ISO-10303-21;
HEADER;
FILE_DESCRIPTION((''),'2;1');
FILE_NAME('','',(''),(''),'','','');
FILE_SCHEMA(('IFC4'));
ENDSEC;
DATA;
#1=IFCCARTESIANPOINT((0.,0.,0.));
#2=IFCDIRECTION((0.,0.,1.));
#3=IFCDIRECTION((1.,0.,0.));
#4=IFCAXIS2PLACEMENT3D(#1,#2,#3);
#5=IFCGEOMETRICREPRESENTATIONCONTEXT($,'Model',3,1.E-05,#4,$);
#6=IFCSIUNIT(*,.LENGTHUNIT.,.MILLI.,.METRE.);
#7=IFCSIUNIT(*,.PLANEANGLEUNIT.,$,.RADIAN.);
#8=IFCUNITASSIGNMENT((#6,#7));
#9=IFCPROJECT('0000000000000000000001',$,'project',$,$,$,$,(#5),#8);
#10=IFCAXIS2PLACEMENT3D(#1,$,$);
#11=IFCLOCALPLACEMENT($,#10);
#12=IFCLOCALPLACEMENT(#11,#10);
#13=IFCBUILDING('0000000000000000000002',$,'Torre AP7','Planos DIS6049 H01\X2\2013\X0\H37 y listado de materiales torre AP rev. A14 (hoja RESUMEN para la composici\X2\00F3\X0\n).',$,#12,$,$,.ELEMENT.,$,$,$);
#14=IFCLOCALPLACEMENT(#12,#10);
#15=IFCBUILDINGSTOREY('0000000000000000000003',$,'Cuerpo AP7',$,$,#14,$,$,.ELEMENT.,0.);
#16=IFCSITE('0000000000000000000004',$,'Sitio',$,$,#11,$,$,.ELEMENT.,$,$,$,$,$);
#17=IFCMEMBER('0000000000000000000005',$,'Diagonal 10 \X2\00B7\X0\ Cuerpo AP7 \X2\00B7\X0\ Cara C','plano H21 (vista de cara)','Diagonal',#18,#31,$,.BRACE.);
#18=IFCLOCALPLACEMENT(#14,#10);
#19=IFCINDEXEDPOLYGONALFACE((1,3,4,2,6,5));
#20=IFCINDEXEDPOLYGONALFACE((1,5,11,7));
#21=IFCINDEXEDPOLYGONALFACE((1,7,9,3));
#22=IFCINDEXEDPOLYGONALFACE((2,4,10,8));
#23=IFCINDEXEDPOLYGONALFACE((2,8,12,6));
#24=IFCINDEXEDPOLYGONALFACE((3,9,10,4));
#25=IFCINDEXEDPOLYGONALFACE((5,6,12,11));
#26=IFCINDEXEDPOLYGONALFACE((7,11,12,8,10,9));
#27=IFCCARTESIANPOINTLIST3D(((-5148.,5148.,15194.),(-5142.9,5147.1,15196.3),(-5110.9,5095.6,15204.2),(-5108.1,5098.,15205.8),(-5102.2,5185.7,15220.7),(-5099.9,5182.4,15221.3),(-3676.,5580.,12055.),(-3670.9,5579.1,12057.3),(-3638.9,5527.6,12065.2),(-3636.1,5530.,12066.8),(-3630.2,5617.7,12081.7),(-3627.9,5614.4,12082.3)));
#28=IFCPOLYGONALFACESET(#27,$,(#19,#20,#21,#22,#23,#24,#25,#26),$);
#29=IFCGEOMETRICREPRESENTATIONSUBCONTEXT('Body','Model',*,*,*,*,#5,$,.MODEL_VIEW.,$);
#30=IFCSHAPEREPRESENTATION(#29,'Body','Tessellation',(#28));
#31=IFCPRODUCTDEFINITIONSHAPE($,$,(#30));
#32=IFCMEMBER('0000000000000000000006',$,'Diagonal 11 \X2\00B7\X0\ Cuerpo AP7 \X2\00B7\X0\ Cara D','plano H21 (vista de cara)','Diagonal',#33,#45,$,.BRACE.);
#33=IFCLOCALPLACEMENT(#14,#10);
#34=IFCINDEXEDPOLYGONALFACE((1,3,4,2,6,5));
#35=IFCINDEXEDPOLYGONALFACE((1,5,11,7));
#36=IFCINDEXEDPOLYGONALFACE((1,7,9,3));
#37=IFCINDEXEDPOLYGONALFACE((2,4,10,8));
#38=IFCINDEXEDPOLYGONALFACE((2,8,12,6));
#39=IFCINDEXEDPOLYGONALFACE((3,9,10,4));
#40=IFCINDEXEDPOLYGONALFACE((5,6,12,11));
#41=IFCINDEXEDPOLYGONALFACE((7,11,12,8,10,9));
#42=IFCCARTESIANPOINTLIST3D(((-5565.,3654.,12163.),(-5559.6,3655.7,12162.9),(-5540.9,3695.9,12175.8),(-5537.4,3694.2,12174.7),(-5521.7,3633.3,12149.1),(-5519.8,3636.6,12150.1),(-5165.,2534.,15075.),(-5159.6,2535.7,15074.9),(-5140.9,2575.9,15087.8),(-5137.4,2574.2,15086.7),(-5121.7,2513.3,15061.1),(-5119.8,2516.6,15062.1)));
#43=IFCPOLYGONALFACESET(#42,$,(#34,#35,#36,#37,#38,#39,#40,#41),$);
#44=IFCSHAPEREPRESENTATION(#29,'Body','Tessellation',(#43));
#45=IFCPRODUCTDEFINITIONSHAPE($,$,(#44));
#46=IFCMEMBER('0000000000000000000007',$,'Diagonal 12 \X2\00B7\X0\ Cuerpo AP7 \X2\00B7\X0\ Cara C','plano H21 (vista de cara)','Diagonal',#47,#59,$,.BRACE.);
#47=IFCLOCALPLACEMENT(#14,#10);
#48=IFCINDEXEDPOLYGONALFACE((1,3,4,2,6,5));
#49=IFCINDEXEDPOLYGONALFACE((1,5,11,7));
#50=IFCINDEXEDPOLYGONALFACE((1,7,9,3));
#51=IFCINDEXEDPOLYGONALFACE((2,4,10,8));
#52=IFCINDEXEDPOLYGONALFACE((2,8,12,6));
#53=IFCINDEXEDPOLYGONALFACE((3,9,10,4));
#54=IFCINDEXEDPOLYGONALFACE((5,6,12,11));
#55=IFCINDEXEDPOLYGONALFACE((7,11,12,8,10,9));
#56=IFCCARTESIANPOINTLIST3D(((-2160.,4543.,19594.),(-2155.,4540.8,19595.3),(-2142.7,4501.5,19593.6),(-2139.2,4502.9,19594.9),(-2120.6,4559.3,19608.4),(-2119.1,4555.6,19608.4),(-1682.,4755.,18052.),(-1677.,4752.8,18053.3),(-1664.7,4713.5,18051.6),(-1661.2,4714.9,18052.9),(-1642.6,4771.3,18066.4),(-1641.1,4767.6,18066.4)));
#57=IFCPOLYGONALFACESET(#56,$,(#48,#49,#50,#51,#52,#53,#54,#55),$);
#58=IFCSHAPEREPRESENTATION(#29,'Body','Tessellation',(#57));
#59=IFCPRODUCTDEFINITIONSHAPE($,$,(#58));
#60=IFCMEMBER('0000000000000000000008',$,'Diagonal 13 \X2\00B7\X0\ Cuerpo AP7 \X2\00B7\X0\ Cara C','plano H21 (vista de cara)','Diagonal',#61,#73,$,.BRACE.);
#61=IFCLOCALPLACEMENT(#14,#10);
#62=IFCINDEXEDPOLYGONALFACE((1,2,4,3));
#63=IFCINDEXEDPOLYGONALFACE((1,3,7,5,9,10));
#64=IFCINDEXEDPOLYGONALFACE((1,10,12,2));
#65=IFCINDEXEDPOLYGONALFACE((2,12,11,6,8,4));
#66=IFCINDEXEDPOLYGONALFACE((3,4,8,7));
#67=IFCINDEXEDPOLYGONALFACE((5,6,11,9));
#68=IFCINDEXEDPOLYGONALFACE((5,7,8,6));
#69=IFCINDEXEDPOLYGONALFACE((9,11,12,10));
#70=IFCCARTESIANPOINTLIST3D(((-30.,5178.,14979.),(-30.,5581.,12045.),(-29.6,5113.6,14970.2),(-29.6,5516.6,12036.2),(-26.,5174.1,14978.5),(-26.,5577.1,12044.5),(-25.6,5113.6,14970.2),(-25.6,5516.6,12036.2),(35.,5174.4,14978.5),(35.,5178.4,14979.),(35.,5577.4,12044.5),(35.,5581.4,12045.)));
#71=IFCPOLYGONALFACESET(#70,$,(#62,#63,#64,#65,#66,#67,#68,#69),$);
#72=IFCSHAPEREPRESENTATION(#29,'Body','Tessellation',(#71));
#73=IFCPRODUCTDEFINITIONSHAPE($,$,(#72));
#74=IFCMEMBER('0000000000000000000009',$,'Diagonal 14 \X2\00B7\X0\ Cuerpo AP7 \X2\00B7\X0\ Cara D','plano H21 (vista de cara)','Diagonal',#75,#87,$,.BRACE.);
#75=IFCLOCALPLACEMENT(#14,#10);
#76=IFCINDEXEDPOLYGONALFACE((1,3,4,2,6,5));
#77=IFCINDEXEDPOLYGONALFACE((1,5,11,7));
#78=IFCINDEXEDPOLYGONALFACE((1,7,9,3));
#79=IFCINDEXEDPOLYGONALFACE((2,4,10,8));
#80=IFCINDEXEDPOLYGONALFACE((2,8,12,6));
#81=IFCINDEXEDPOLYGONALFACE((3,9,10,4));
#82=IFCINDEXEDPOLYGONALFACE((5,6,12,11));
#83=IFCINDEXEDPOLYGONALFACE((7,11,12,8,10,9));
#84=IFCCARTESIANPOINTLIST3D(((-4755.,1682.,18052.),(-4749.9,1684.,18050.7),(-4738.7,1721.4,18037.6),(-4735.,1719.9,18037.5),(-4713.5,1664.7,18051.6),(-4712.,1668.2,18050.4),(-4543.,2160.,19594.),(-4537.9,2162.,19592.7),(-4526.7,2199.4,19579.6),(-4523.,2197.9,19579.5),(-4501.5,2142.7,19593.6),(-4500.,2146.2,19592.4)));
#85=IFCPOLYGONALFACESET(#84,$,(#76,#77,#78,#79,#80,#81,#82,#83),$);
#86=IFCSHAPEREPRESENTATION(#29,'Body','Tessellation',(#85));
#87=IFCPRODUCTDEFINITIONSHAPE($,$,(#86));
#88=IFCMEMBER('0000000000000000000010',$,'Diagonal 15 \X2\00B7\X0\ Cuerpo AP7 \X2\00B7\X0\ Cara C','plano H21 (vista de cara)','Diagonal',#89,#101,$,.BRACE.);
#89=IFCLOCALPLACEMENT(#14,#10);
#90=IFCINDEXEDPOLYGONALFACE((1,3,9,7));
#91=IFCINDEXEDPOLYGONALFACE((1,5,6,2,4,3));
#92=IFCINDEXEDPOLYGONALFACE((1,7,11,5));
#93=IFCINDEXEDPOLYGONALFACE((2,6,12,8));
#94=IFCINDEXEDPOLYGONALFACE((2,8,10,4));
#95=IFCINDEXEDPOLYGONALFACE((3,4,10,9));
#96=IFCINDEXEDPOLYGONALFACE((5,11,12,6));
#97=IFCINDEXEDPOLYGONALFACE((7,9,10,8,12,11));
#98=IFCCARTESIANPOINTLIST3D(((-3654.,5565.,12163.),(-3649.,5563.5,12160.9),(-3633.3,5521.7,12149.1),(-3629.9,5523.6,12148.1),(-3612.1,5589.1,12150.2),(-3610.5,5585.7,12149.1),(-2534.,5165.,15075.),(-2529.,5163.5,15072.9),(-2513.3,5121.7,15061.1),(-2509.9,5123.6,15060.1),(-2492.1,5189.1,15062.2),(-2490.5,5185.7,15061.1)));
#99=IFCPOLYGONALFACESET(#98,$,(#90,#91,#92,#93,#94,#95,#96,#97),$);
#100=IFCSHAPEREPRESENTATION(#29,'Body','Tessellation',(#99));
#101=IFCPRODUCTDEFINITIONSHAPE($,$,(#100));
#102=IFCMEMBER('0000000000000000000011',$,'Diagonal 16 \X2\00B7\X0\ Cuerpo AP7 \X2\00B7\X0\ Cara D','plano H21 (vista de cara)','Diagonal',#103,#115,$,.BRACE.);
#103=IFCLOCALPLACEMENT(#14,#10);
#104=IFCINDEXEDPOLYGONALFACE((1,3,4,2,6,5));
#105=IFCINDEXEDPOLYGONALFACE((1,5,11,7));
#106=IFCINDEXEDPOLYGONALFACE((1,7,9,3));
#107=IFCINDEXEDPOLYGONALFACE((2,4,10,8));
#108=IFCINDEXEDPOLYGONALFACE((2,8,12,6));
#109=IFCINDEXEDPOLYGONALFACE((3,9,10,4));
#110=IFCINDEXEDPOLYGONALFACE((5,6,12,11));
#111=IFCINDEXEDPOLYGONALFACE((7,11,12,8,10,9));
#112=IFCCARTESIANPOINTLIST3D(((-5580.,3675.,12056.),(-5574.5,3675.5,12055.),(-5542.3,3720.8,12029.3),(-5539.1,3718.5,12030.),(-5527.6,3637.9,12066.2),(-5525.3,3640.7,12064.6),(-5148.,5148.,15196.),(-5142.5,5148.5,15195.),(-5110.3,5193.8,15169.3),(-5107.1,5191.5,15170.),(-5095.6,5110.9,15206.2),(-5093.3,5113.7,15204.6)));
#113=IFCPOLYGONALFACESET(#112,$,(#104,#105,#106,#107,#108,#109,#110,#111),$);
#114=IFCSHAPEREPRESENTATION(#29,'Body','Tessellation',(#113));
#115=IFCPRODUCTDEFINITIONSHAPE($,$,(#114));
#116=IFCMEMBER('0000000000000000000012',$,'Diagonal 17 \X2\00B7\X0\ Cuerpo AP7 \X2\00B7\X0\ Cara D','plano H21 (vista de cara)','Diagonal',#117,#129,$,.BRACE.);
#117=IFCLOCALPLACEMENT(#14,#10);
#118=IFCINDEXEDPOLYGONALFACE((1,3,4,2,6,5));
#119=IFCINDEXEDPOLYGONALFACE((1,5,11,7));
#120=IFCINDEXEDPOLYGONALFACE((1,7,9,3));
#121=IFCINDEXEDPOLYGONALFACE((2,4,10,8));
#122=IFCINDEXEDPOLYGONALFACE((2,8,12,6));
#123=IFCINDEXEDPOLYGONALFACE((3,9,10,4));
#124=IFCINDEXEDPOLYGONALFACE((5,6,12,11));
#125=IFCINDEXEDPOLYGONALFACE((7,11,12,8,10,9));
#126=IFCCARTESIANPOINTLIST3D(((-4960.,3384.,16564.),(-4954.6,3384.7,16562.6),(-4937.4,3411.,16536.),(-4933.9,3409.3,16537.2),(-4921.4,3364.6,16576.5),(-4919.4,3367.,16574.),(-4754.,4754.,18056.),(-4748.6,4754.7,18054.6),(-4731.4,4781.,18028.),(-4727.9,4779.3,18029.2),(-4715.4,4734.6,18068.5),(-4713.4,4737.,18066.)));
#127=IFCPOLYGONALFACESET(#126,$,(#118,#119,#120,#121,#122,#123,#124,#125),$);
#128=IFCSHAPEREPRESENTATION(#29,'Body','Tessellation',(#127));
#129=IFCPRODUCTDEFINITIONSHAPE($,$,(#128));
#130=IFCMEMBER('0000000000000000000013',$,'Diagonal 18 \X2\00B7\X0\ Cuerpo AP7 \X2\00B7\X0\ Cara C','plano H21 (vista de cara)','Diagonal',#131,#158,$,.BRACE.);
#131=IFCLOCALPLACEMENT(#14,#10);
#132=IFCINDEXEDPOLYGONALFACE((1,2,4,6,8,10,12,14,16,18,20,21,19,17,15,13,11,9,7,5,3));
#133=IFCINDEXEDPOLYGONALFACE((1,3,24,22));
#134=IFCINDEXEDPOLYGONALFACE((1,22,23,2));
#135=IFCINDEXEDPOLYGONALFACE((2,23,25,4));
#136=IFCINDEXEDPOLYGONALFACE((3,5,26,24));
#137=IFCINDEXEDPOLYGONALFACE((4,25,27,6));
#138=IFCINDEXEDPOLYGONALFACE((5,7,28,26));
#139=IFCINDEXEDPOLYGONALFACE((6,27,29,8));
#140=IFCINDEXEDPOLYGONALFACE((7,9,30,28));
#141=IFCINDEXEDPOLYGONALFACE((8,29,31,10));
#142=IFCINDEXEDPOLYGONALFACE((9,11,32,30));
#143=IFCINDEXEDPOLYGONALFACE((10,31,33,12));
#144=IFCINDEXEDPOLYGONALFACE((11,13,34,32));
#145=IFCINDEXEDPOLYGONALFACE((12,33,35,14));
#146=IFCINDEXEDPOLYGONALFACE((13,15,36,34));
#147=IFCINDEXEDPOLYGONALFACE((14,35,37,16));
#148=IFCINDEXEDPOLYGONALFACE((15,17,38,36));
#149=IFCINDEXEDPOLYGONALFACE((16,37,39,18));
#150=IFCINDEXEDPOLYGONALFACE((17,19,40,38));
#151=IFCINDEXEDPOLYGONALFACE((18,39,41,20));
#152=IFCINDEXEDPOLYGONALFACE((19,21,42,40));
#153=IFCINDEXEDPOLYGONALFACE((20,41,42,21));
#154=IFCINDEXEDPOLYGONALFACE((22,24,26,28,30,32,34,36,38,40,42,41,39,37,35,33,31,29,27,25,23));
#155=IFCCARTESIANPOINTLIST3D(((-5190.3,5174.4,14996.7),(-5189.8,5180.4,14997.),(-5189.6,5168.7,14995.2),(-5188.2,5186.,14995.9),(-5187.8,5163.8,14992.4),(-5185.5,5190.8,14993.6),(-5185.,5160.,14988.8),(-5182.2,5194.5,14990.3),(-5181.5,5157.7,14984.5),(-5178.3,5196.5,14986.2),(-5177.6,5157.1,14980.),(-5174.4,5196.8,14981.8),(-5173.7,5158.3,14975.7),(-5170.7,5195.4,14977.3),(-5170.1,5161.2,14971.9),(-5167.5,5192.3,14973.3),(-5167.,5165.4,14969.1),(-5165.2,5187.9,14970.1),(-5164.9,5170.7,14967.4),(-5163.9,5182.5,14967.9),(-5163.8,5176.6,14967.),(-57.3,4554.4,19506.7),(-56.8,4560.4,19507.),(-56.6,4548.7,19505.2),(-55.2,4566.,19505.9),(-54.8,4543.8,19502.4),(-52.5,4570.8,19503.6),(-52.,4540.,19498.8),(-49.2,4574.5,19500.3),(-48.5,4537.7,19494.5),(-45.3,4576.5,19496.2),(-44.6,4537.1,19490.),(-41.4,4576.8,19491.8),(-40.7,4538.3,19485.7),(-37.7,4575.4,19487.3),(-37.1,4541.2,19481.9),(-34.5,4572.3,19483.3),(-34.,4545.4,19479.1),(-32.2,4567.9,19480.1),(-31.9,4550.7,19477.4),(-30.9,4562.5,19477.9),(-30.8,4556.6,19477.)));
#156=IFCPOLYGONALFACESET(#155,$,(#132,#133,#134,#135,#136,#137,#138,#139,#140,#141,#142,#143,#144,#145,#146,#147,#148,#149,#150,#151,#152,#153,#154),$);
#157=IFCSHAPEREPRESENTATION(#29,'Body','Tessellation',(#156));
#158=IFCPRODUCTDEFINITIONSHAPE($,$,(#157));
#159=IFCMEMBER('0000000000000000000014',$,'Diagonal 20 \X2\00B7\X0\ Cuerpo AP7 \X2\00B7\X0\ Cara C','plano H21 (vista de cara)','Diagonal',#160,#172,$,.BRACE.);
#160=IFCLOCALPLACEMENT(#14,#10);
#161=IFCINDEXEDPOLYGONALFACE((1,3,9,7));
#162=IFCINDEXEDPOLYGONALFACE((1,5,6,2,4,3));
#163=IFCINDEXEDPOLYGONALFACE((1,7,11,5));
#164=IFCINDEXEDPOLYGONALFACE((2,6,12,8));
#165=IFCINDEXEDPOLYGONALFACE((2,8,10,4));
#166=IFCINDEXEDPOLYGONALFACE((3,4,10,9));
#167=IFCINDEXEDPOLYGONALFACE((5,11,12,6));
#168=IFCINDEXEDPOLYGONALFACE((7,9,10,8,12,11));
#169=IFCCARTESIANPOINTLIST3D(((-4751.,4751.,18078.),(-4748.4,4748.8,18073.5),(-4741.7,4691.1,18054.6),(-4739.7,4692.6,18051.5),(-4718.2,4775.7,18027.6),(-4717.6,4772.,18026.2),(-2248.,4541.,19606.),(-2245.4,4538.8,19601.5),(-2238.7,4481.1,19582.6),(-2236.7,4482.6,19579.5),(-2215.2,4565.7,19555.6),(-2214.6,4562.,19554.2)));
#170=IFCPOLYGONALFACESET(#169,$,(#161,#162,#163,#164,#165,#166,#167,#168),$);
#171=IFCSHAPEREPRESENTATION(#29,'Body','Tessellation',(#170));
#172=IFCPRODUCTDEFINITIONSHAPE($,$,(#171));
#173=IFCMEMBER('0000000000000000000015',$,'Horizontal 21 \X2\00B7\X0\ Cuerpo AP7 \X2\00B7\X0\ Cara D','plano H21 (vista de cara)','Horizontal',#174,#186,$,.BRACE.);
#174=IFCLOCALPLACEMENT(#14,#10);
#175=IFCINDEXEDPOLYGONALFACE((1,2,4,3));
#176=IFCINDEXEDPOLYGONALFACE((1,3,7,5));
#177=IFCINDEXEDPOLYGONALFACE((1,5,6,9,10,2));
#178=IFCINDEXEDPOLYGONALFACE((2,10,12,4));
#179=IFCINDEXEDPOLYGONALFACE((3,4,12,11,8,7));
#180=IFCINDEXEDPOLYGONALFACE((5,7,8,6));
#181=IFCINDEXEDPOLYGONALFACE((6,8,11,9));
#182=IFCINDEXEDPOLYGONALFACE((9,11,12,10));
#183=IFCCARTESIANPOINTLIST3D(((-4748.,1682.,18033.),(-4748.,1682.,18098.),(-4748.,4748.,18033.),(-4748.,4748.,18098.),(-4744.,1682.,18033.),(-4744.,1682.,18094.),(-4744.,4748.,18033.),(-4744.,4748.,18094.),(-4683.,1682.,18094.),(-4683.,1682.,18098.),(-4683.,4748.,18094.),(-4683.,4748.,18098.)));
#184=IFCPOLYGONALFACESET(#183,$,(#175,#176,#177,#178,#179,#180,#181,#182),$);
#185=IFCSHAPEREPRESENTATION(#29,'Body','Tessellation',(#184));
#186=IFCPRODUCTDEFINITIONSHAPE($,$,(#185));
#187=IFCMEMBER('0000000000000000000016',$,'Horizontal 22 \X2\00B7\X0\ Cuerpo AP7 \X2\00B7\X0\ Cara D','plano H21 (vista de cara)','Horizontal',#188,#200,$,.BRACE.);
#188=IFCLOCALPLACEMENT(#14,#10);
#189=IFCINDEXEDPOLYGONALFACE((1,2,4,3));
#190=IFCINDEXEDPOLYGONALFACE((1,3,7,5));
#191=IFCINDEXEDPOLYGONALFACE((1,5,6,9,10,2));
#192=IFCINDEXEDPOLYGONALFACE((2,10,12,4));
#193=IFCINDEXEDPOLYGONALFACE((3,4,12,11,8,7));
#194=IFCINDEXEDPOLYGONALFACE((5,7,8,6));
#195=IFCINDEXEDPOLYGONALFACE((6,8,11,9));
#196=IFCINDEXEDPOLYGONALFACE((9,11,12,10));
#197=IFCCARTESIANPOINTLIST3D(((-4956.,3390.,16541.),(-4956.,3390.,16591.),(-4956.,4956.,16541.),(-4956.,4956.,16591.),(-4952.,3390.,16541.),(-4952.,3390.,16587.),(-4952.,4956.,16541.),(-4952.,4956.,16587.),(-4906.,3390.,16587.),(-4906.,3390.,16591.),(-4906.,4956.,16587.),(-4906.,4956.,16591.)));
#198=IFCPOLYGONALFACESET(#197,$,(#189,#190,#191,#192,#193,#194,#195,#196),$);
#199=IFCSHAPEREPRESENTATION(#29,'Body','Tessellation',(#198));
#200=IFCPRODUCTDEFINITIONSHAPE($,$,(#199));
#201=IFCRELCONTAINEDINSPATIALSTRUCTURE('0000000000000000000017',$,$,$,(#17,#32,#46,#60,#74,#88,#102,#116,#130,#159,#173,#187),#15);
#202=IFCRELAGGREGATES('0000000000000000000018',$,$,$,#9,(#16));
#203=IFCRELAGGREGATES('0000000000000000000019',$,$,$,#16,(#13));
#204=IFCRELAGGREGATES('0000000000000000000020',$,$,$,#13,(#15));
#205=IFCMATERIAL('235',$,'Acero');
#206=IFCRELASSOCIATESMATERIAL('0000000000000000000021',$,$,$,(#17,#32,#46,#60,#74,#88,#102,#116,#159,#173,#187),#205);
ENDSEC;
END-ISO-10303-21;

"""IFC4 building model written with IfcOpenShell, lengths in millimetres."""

from ifc_helpers import new_model, si_unit, frame, frame_2d, origin, origin_with_axes, place, context, subcontext, project, spatial, circle, l_section, extrude, material, element, save


model = new_model("IFC4")

# Units and contexts
model_context = context("Model", 3, precision=1e-05, world=origin_with_axes())
body_context = subcontext(model_context, "Body", "Model", "MODEL_VIEW")
ifc_project = project(units=[si_unit("LENGTHUNIT", "METRE", prefix="MILLI"), si_unit("PLANEANGLEUNIT", "RADIAN")], contexts=[model_context])

# Site, building, storey
site_placement = place(None, origin())
site = spatial("IfcSite", under=ifc_project, at=site_placement, Name="Sitio", CompositionType="ELEMENT")
building_placement = place(site_placement, origin())
building = spatial("IfcBuilding", under=site, at=building_placement, Name="Torre AP7", Description="Planos DIS6049 H01–H37 y listado de materiales torre AP rev. A14 (hoja RESUMEN para la composición).", CompositionType="ELEMENT")
storey_placement = place(building_placement, origin())
storey = spatial("IfcBuildingStorey", under=building, at=storey_placement, Name="Cuerpo AP7", CompositionType="ELEMENT", Elevation=0.0)

# Members
ifc_material_1 = material(Name="235", Category="Acero")
member_1_placement = place(storey_placement, frame((-3676.0, 5580.0, 12055.0), z_axis=(-0.421316, -0.123647, 0.898445), x_axis=(0.571243, -0.805624, 0.157006)))
element("IfcMember", 1, at=member_1_placement, inside=storey, material=ifc_material_1, Name="Diagonal 10 · Cuerpo AP7 · Cara C", Description="plano H21 (vista de cara)", ObjectType="Diagonal", PredefinedType="BRACE", context=body_context, shape_type="SweptSolid", body=[
    extrude(l_section(Depth=65.0, Width=65.0, Thickness=4.0, at=frame_2d((32.5, 32.5))), None, (0.0, 0.0, 1.0), 3493.8),
])
member_2_placement = place(storey_placement, frame((-5565.0, 3654.0, 12163.0), z_axis=(0.127166, -0.356065, 0.925768), x_axis=(0.866358, -0.414588, -0.278462)))
element("IfcMember", 2, at=member_2_placement, inside=storey, material=ifc_material_1, Name="Diagonal 11 · Cuerpo AP7 · Cara D", Description="plano H21 (vista de cara)", ObjectType="Diagonal", PredefinedType="BRACE", context=body_context, shape_type="SweptSolid", body=[
    extrude(l_section(Depth=50.0, Width=50.0, Thickness=4.0, at=frame_2d((25.0, 25.0))), None, (0.0, 0.0, 1.0), 3145.5),
])
member_3_placement = place(storey_placement, frame((-1682.0, 4755.0, 18052.0), z_axis=(-0.293567, -0.130201, 0.94703), x_axis=(0.384316, -0.923169, -0.007788)))
element("IfcMember", 3, at=member_3_placement, inside=storey, material=ifc_material_1, Name="Diagonal 12 · Cuerpo AP7 · Cara C", Description="plano H21 (vista de cara)", ObjectType="Diagonal", PredefinedType="BRACE", context=body_context, shape_type="SweptSolid", body=[
    extrude(l_section(Depth=45.0, Width=45.0, Thickness=4.0, at=frame_2d((22.5, 22.5))), None, (0.0, 0.0, 1.0), 1628.2),
])
member_4_placement = place(storey_placement, frame((-30.0, 5581.0, 12045.0), z_axis=(0.0, -0.136077, 0.990698), x_axis=(0.005629, -0.990683, -0.136075)))
element("IfcMember", 4, at=member_4_placement, inside=storey, material=ifc_material_1, Name="Diagonal 13 · Cuerpo AP7 · Cara C", Description="plano H21 (vista de cara)", ObjectType="Diagonal", PredefinedType="BRACE", context=body_context, shape_type="SweptSolid", body=[
    extrude(l_section(Depth=65.0, Width=65.0, Thickness=4.0, at=frame_2d((32.5, 32.5))), None, (0.0, 0.0, 1.0), 2961.5),
])
member_5_placement = place(storey_placement, frame((-4755.0, 1682.0, 18052.0), z_axis=(0.130201, 0.293567, 0.94703), x_axis=(0.923169, -0.384316, -0.007788)))
element("IfcMember", 5, at=member_5_placement, inside=storey, material=ifc_material_1, Name="Diagonal 14 · Cuerpo AP7 · Cara D", Description="plano H21 (vista de cara)", ObjectType="Diagonal", PredefinedType="BRACE", context=body_context, shape_type="SweptSolid", body=[
    extrude(l_section(Depth=45.0, Width=45.0, Thickness=4.0, at=frame_2d((22.5, 22.5))), None, (0.0, 0.0, 1.0), 1628.2),
])
member_6_placement = place(storey_placement, frame((-3654.0, 5565.0, 12163.0), z_axis=(0.356065, -0.127166, 0.925768), x_axis=(0.414588, -0.866358, -0.278462)))
element("IfcMember", 6, at=member_6_placement, inside=storey, material=ifc_material_1, Name="Diagonal 15 · Cuerpo AP7 · Cara C", Description="plano H21 (vista de cara)", ObjectType="Diagonal", PredefinedType="BRACE", context=body_context, shape_type="SweptSolid", body=[
    extrude(l_section(Depth=50.0, Width=50.0, Thickness=4.0, at=frame_2d((25.0, 25.0))), None, (0.0, 0.0, 1.0), 3145.5),
])
member_7_placement = place(storey_placement, frame((-5580.0, 3675.0, 12056.0), z_axis=(0.1236, 0.421443, 0.898392), x_axis=(0.805677, -0.571147, 0.157085)))
element("IfcMember", 7, at=member_7_placement, inside=storey, material=ifc_material_1, Name="Diagonal 16 · Cuerpo AP7 · Cara D", Description="plano H21 (vista de cara)", ObjectType="Diagonal", PredefinedType="BRACE", context=body_context, shape_type="SweptSolid", body=[
    extrude(l_section(Depth=65.0, Width=65.0, Thickness=4.0, at=frame_2d((32.5, 32.5))), None, (0.0, 0.0, 1.0), 3495.1),
])
member_8_placement = place(storey_placement, frame((-4960.0, 3384.0, 16564.0), z_axis=(0.101178, 0.67288, 0.7328), x_axis=(0.858174, -0.431654, 0.27787)))
element("IfcMember", 8, at=member_8_placement, inside=storey, material=ifc_material_1, Name="Diagonal 17 · Cuerpo AP7 · Cara D", Description="plano H21 (vista de cara)", ObjectType="Diagonal", PredefinedType="BRACE", context=body_context, shape_type="SweptSolid", body=[
    extrude(l_section(Depth=45.0, Width=45.0, Thickness=4.0, at=frame_2d((22.5, 22.5))), None, (0.0, 0.0, 1.0), 2036.0),
])
member_9_placement = place(storey_placement, frame((-5177.0, 5177.0, 14982.0), z_axis=(0.748151, -0.090367, 0.657346), x_axis=(0.164794, -0.934337, -0.316003)))
element("IfcMember", 9, at=member_9_placement, inside=storey, Name="Diagonal 18 · Cuerpo AP7 · Cara C", Description="plano H21 (vista de cara)", ObjectType="Diagonal", PredefinedType="BRACE", context=body_context, shape_type="SweptSolid", body=[
    extrude(circle(Radius=20.0), None, (0.0, 0.0, 1.0), 6860.9),
])
member_10_placement = place(storey_placement, frame((-4751.0, 4751.0, 18078.0), z_axis=(0.851346, -0.071427, 0.519719), x_axis=(0.142318, -0.922089, -0.359857)))
element("IfcMember", 10, at=member_10_placement, inside=storey, material=ifc_material_1, Name="Diagonal 20 · Cuerpo AP7 · Cara C", Description="plano H21 (vista de cara)", ObjectType="Diagonal", PredefinedType="BRACE", context=body_context, shape_type="SweptSolid", body=[
    extrude(l_section(Depth=65.0, Width=65.0, Thickness=4.0, at=frame_2d((32.5, 32.5))), None, (0.0, 0.0, 1.0), 2940.0),
])
member_11_placement = place(storey_placement, frame((-4748.0, 1682.0, 18098.0), z_axis=(0.0, 1.0, 0.0), x_axis=(1.0, 0.0, 0.0)))
element("IfcMember", 11, at=member_11_placement, inside=storey, material=ifc_material_1, Name="Horizontal 21 · Cuerpo AP7 · Cara D", Description="plano H21 (vista de cara)", ObjectType="Horizontal", PredefinedType="BRACE", context=body_context, shape_type="SweptSolid", body=[
    extrude(l_section(Depth=65.0, Width=65.0, Thickness=4.0, at=frame_2d((32.5, 32.5))), None, (0.0, 0.0, 1.0), 3066.0),
])
member_12_placement = place(storey_placement, frame((-4956.0, 3390.0, 16591.0), z_axis=(0.0, 1.0, 0.0), x_axis=(1.0, 0.0, 0.0)))
element("IfcMember", 12, at=member_12_placement, inside=storey, material=ifc_material_1, Name="Horizontal 22 · Cuerpo AP7 · Cara D", Description="plano H21 (vista de cara)", ObjectType="Horizontal", PredefinedType="BRACE", context=body_context, shape_type="SweptSolid", body=[
    extrude(l_section(Depth=50.0, Width=50.0, Thickness=4.0, at=frame_2d((25.0, 25.0))), None, (0.0, 0.0, 1.0), 1566.0),
])

save(model, "model.ifc")
